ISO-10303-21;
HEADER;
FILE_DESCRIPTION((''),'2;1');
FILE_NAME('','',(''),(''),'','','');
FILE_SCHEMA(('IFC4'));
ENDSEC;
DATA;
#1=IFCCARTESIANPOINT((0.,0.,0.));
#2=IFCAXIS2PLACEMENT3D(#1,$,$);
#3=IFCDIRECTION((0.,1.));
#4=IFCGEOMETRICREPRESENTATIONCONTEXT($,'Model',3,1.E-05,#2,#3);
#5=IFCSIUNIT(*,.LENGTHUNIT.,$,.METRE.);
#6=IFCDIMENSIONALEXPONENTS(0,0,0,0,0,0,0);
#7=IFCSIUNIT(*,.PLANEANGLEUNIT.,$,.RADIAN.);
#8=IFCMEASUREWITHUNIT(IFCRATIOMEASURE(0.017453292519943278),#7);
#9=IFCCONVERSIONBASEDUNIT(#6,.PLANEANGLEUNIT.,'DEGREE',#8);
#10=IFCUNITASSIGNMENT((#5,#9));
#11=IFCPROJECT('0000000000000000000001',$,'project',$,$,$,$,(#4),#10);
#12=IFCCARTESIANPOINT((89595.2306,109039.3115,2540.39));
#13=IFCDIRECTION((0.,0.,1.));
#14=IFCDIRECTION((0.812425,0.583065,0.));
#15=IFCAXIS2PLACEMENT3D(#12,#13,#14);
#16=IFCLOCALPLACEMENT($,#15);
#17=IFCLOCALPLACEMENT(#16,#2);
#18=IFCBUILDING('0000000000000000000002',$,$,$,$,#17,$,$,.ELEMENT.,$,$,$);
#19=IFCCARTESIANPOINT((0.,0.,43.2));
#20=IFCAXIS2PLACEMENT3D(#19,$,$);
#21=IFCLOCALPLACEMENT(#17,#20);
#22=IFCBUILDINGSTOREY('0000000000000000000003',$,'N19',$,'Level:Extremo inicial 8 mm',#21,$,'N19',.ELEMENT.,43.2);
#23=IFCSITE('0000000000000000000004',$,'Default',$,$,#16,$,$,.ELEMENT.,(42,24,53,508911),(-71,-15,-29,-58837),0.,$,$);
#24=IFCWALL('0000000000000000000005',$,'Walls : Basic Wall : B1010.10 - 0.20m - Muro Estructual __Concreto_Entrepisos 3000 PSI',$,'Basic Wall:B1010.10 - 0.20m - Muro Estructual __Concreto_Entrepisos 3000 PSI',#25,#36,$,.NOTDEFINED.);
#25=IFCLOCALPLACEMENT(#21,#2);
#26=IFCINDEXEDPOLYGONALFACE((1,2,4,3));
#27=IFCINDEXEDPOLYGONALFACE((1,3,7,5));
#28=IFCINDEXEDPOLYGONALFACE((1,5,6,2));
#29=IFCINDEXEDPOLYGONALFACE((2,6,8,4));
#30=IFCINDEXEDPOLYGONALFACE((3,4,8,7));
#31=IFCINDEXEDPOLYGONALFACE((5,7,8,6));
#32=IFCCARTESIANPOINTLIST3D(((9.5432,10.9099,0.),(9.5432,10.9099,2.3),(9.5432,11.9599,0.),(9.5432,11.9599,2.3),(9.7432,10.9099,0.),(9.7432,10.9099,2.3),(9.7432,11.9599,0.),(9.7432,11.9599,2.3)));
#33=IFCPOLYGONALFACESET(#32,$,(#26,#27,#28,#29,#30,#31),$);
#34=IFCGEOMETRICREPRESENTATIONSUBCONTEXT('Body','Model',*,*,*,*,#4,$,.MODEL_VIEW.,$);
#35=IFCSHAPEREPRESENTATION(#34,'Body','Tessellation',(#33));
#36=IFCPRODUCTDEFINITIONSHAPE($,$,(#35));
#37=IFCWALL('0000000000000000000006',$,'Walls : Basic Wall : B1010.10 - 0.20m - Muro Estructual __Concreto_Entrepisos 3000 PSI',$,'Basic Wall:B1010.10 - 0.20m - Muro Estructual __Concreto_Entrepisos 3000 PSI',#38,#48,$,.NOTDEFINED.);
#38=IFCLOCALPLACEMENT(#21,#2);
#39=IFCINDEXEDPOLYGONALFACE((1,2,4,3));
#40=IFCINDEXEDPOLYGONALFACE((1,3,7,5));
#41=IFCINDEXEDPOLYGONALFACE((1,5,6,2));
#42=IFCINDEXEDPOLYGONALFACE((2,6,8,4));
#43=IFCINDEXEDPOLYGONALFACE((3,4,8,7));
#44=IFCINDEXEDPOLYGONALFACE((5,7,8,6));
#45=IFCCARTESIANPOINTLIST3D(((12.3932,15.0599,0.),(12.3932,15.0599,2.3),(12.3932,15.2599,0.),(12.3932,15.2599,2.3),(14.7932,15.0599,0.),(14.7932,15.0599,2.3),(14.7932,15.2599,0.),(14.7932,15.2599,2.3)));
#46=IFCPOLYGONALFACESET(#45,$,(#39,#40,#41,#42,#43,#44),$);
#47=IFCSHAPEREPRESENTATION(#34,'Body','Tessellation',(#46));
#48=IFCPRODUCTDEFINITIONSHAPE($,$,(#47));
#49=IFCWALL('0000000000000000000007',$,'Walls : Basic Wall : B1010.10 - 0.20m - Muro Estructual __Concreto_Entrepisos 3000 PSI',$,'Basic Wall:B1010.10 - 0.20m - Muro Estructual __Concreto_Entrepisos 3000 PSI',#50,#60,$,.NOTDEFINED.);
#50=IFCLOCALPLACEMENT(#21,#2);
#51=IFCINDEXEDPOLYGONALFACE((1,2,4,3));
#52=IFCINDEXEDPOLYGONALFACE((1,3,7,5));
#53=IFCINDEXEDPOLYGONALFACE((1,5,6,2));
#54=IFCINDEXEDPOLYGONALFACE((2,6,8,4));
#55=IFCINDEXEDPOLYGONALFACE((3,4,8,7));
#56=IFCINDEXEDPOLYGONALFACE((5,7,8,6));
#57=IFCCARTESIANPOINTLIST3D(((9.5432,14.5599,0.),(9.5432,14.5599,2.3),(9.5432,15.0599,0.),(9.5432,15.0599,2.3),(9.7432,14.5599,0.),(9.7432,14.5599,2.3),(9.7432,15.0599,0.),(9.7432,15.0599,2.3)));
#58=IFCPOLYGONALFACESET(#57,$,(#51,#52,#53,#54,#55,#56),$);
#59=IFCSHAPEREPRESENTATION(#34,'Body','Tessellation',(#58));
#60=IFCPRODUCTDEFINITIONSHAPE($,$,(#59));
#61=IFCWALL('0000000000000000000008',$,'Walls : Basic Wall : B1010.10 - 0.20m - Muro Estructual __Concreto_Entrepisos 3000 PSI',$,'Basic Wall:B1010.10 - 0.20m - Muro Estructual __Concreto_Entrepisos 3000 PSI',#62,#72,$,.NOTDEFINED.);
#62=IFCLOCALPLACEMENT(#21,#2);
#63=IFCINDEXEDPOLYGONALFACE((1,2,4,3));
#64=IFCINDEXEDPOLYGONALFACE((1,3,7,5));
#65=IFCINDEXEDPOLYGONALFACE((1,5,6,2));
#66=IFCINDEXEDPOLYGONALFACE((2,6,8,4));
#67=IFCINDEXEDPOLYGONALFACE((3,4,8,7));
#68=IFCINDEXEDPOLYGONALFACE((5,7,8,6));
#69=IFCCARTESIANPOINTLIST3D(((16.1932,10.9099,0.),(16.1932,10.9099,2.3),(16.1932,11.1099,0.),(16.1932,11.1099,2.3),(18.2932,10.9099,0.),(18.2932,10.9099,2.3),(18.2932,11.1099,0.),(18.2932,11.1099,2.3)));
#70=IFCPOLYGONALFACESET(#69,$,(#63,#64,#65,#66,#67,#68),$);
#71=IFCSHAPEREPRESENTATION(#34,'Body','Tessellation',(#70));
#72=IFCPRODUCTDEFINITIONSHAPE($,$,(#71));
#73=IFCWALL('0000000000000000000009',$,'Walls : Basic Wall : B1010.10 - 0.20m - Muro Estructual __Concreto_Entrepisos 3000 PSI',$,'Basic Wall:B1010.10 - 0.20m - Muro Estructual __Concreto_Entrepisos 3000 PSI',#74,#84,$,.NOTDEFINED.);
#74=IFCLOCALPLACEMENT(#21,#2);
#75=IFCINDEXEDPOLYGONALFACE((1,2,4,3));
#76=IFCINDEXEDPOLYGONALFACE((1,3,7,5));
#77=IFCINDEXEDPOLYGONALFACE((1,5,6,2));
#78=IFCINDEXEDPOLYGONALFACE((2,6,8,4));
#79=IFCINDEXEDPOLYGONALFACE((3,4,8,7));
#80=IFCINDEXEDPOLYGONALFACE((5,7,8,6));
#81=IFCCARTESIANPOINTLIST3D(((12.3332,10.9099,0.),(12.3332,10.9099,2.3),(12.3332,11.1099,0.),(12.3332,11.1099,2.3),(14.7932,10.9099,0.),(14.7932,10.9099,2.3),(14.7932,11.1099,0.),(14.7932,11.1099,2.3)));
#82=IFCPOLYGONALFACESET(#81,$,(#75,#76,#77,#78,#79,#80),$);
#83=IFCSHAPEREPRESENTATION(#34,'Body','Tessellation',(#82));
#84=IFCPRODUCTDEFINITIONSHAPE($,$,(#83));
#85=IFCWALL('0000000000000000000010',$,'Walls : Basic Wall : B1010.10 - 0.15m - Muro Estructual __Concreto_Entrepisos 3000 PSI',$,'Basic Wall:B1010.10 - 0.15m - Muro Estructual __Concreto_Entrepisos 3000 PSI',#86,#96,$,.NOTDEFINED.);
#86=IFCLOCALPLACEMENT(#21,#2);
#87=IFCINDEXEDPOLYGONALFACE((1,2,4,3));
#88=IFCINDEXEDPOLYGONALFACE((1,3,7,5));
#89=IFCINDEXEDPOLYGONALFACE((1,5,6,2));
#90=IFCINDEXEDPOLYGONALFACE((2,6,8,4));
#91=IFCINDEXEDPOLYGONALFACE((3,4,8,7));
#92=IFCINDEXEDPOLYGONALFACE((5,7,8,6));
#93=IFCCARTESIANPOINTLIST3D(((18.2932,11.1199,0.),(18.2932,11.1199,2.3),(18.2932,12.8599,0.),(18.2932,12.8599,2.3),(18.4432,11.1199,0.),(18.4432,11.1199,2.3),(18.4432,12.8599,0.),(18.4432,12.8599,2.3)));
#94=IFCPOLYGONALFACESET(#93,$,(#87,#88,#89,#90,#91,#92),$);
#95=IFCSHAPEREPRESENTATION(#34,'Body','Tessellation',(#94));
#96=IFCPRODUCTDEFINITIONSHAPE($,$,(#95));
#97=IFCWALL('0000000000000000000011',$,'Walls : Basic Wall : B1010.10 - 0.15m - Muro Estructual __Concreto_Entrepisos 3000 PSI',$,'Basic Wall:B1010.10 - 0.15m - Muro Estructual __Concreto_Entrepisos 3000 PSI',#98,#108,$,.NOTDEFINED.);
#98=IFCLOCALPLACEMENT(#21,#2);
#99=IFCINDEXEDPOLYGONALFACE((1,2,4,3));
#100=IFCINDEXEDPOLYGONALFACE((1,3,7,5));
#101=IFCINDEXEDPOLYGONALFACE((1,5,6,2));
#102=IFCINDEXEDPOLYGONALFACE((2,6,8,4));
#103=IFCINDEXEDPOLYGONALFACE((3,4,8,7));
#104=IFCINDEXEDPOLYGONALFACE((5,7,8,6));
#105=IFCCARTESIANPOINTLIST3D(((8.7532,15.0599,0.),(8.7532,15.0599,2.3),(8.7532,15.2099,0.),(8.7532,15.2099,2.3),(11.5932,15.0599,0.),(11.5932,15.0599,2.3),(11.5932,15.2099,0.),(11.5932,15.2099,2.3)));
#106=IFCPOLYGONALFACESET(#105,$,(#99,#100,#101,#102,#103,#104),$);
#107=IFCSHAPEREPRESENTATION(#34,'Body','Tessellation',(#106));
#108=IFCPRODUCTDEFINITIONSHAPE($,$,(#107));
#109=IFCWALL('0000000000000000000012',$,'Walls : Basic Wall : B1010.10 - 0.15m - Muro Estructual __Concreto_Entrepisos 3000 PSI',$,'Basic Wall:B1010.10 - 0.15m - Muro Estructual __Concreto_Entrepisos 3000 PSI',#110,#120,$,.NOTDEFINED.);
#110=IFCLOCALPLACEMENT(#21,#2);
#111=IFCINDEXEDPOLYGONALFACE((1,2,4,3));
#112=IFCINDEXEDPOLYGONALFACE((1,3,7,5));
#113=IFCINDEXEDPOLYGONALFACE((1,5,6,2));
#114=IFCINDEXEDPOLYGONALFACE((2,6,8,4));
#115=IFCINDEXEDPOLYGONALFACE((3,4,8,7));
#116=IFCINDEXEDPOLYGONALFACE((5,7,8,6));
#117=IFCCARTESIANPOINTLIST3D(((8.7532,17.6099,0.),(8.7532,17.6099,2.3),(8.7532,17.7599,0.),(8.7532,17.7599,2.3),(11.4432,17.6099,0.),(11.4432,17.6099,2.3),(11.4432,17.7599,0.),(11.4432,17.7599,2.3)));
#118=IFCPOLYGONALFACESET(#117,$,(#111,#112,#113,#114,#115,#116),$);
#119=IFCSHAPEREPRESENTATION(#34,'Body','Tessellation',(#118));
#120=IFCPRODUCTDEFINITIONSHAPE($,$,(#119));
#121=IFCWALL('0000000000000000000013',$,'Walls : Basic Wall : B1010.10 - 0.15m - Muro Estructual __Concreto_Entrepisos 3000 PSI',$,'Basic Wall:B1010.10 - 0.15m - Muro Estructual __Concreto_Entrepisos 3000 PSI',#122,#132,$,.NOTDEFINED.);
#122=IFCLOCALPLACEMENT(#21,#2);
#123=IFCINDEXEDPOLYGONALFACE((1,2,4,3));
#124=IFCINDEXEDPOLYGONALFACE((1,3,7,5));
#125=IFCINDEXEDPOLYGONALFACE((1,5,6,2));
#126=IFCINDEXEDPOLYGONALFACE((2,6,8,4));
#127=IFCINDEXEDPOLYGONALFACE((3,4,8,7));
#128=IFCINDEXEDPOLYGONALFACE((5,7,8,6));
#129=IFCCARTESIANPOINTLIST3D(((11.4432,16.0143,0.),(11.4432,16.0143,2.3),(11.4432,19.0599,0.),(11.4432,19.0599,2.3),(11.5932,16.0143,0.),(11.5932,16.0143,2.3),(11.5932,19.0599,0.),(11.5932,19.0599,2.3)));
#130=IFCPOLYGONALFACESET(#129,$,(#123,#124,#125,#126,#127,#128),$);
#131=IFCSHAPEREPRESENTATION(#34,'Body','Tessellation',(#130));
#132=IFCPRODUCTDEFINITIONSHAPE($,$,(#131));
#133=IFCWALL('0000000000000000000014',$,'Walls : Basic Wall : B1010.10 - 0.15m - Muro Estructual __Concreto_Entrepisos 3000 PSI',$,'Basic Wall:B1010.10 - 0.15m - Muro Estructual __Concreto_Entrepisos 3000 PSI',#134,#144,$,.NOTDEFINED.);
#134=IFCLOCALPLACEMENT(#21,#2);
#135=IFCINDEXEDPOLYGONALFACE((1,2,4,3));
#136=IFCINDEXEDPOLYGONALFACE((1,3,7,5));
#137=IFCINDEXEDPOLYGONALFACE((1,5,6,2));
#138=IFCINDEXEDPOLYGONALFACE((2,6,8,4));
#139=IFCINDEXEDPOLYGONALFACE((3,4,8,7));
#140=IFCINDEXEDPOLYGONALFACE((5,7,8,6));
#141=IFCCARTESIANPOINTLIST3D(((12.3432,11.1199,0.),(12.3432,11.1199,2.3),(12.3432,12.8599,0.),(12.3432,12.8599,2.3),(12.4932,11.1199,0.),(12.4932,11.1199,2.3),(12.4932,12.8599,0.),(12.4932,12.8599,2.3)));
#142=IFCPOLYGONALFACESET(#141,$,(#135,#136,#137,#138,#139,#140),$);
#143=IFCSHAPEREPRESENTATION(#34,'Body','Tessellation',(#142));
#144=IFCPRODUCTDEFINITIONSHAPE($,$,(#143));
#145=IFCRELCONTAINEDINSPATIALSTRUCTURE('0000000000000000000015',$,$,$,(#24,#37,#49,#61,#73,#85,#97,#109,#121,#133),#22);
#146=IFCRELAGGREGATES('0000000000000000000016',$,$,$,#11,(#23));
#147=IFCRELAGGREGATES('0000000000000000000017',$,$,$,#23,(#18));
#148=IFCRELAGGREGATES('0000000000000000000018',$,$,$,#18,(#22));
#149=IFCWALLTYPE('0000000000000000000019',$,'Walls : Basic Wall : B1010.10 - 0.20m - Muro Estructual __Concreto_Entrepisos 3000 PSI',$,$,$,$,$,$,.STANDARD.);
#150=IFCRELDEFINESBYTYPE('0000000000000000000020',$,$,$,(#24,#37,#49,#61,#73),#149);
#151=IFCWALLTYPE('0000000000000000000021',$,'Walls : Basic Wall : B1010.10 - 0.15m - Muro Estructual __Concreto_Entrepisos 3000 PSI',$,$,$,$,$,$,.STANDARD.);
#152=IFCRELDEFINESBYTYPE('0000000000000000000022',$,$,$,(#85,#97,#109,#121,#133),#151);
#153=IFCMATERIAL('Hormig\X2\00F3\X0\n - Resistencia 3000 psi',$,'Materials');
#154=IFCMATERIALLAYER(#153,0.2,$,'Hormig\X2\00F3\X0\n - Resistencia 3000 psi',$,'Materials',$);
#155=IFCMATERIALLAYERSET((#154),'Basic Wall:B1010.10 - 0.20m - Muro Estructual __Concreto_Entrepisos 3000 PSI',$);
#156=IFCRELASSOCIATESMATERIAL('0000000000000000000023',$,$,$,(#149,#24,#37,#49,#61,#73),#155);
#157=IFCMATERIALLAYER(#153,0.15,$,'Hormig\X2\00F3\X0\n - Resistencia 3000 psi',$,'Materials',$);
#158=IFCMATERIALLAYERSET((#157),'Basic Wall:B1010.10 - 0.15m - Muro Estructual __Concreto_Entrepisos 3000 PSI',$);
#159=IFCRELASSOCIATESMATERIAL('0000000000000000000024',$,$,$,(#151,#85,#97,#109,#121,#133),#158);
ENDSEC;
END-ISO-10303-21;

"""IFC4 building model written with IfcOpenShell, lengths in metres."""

from ifc_helpers import new_model, entity, si_unit, converted_unit, direction, frame, frame_2d, origin, place, context, subcontext, project, spatial, rectangle, extrude, material, layer, layer_set, layer_usage, type_object, element, save


model = new_model("IFC4")

# Units and contexts
model_context = context("Model", 3, precision=1e-05, world=origin(), true_north=direction((0.0, 1.0)))
body_context = subcontext(model_context, "Body", "Model", "MODEL_VIEW")
ifc_project = project(units=[si_unit("LENGTHUNIT", "METRE"), converted_unit("PLANEANGLEUNIT", "DEGREE", entity("IfcRatioMeasure", 0.017453292519943278), si_unit("PLANEANGLEUNIT", "RADIAN"), dimensions=[0, 0, 0, 0, 0, 0, 0])], contexts=[model_context])

# Site, building, storey
site_placement = place(None, frame((89595.2306, 109039.3115, 2540.39), z_axis=(0.0, 0.0, 1.0), x_axis=(0.812425, 0.583065, 0.0)))
site = spatial("IfcSite", under=ifc_project, at=site_placement, Name="Default", CompositionType="ELEMENT", RefLatitude=(42, 24, 53, 508911), RefLongitude=(-71, -15, -29, -58837), RefElevation=0.0)
building_placement = place(site_placement, origin())
building = spatial("IfcBuilding", under=site, at=building_placement, CompositionType="ELEMENT")
storey_placement = place(building_placement, frame((0.0, 0.0, 43.2)))
storey = spatial("IfcBuildingStorey", under=building, at=storey_placement, Name="N19", ObjectType="Level:Extremo inicial 8 mm", LongName="N19", CompositionType="ELEMENT", Elevation=43.2)

# Walls
ifc_material = material(Name="Hormigón - Resistencia 3000 psi", Category="Materials")
ifc_layer_1 = layer(ifc_material, 0.2, Name="Hormigón - Resistencia 3000 psi", Category="Materials")
ifc_layer_set_1 = layer_set([ifc_layer_1], Name="Basic Wall:B1010.10 - 0.20m - Muro Estructual __Concreto_Entrepisos 3000 PSI")
ifc_layer_usage_1 = layer_usage(ifc_layer_set_1, "AXIS2", "POSITIVE", -0.1)
wall_type_1 = type_object("IfcWallType", Name="Walls : Basic Wall : B1010.10 - 0.20m - Muro Estructual __Concreto_Entrepisos 3000 PSI", PredefinedType="STANDARD", material=ifc_layer_set_1)
wall_1_placement = place(storey_placement, frame((9.6432, 11.9599, 0.0), z_axis=(0.0, 0.0, 1.0), x_axis=(0.0, -1.0, 0.0)))
element("IfcWall", 1, at=wall_1_placement, inside=storey, type_object=wall_type_1, material=ifc_layer_usage_1, Name="Walls : Basic Wall : B1010.10 - 0.20m - Muro Estructual __Concreto_Entrepisos 3000 PSI", ObjectType="Basic Wall:B1010.10 - 0.20m - Muro Estructual __Concreto_Entrepisos 3000 PSI", PredefinedType="NOTDEFINED", context=body_context, shape_type="SweptSolid", body=[
    extrude(rectangle(XDim=1.05, YDim=0.2, at=frame_2d((0.525, 0.0), x_axis=(-1.0, 0.0))), origin(), (0.0, 0.0, 1.0), 2.3),
])
ifc_layer_usage_2 = layer_usage(ifc_layer_set_1, "AXIS2", "POSITIVE", -0.1)
wall_2_placement = place(storey_placement, frame((12.3932, 15.1599, 0.0)))
element("IfcWall", 2, at=wall_2_placement, inside=storey, type_object=wall_type_1, material=ifc_layer_usage_2, Name="Walls : Basic Wall : B1010.10 - 0.20m - Muro Estructual __Concreto_Entrepisos 3000 PSI", ObjectType="Basic Wall:B1010.10 - 0.20m - Muro Estructual __Concreto_Entrepisos 3000 PSI", PredefinedType="NOTDEFINED", context=body_context, shape_type="SweptSolid", body=[
    extrude(rectangle(XDim=2.4, YDim=0.2, at=frame_2d((1.2, 0.0), x_axis=(-1.0, 0.0))), origin(), (0.0, 0.0, 1.0), 2.3),
])
ifc_layer_usage_3 = layer_usage(ifc_layer_set_1, "AXIS2", "POSITIVE", -0.1)
wall_3_placement = place(storey_placement, frame((9.6432, 14.5599, 0.0), z_axis=(0.0, 0.0, 1.0), x_axis=(0.0, 1.0, 0.0)))
element("IfcWall", 3, at=wall_3_placement, inside=storey, type_object=wall_type_1, material=ifc_layer_usage_3, Name="Walls : Basic Wall : B1010.10 - 0.20m - Muro Estructual __Concreto_Entrepisos 3000 PSI", ObjectType="Basic Wall:B1010.10 - 0.20m - Muro Estructual __Concreto_Entrepisos 3000 PSI", PredefinedType="NOTDEFINED", context=body_context, shape_type="SweptSolid", body=[
    extrude(rectangle(XDim=0.5, YDim=0.2, at=frame_2d((0.25, 0.0), x_axis=(-1.0, 0.0))), origin(), (0.0, 0.0, 1.0), 2.3),
])
ifc_layer_usage_4 = layer_usage(ifc_layer_set_1, "AXIS2", "NEGATIVE", 0.1)
wall_4_placement = place(storey_placement, frame((18.2932, 11.0099, 0.0), z_axis=(0.0, 0.0, 1.0), x_axis=(-1.0, 0.0, 0.0)))
element("IfcWall", 4, at=wall_4_placement, inside=storey, type_object=wall_type_1, material=ifc_layer_usage_4, Name="Walls : Basic Wall : B1010.10 - 0.20m - Muro Estructual __Concreto_Entrepisos 3000 PSI", ObjectType="Basic Wall:B1010.10 - 0.20m - Muro Estructual __Concreto_Entrepisos 3000 PSI", PredefinedType="NOTDEFINED", context=body_context, shape_type="SweptSolid", body=[
    extrude(rectangle(XDim=2.1, YDim=0.2, at=frame_2d((1.05, 0.0), x_axis=(-1.0, 0.0))), origin(), (0.0, 0.0, 1.0), 2.3),
])
ifc_layer_usage_5 = layer_usage(ifc_layer_set_1, "AXIS2", "POSITIVE", -0.1)
wall_5_placement = place(storey_placement, frame((12.3332, 11.0099, 0.0)))
element("IfcWall", 5, at=wall_5_placement, inside=storey, type_object=wall_type_1, material=ifc_layer_usage_5, Name="Walls : Basic Wall : B1010.10 - 0.20m - Muro Estructual __Concreto_Entrepisos 3000 PSI", ObjectType="Basic Wall:B1010.10 - 0.20m - Muro Estructual __Concreto_Entrepisos 3000 PSI", PredefinedType="NOTDEFINED", context=body_context, shape_type="SweptSolid", body=[
    extrude(rectangle(XDim=2.46, YDim=0.2, at=frame_2d((1.23, 0.0), x_axis=(-1.0, 0.0))), origin(), (0.0, 0.0, 1.0), 2.3),
])
ifc_layer_2 = layer(ifc_material, 0.15, Name="Hormigón - Resistencia 3000 psi", Category="Materials")
ifc_layer_set_2 = layer_set([ifc_layer_2], Name="Basic Wall:B1010.10 - 0.15m - Muro Estructual __Concreto_Entrepisos 3000 PSI")
ifc_layer_usage_6 = layer_usage(ifc_layer_set_2, "AXIS2", "NEGATIVE", 0.075)
wall_type_2 = type_object("IfcWallType", Name="Walls : Basic Wall : B1010.10 - 0.15m - Muro Estructual __Concreto_Entrepisos 3000 PSI", PredefinedType="STANDARD", material=ifc_layer_set_2)
wall_6_placement = place(storey_placement, frame((18.3682, 11.1199, 0.0), z_axis=(0.0, 0.0, 1.0), x_axis=(0.0, 1.0, 0.0)))
element("IfcWall", 6, at=wall_6_placement, inside=storey, type_object=wall_type_2, material=ifc_layer_usage_6, Name="Walls : Basic Wall : B1010.10 - 0.15m - Muro Estructual __Concreto_Entrepisos 3000 PSI", ObjectType="Basic Wall:B1010.10 - 0.15m - Muro Estructual __Concreto_Entrepisos 3000 PSI", PredefinedType="NOTDEFINED", context=body_context, shape_type="SweptSolid", body=[
    extrude(rectangle(XDim=1.74, YDim=0.15, at=frame_2d((0.87, 0.0), x_axis=(-1.0, 0.0))), origin(), (0.0, 0.0, 1.0), 2.3),
])
ifc_layer_usage_7 = layer_usage(ifc_layer_set_2, "AXIS2", "POSITIVE", -0.075)
wall_7_placement = place(storey_placement, frame((8.7532, 15.1349, 0.0)))
element("IfcWall", 7, at=wall_7_placement, inside=storey, type_object=wall_type_2, material=ifc_layer_usage_7, Name="Walls : Basic Wall : B1010.10 - 0.15m - Muro Estructual __Concreto_Entrepisos 3000 PSI", ObjectType="Basic Wall:B1010.10 - 0.15m - Muro Estructual __Concreto_Entrepisos 3000 PSI", PredefinedType="NOTDEFINED", context=body_context, shape_type="SweptSolid", body=[
    extrude(rectangle(XDim=2.84, YDim=0.15, at=frame_2d((1.42, 0.0), x_axis=(-1.0, 0.0))), origin(), (0.0, 0.0, 1.0), 2.3),
])
ifc_layer_usage_8 = layer_usage(ifc_layer_set_2, "AXIS2", "POSITIVE", -0.075)
wall_8_placement = place(storey_placement, frame((8.7532, 17.6849, 0.0)))
element("IfcWall", 8, at=wall_8_placement, inside=storey, type_object=wall_type_2, material=ifc_layer_usage_8, Name="Walls : Basic Wall : B1010.10 - 0.15m - Muro Estructual __Concreto_Entrepisos 3000 PSI", ObjectType="Basic Wall:B1010.10 - 0.15m - Muro Estructual __Concreto_Entrepisos 3000 PSI", PredefinedType="NOTDEFINED", context=body_context, shape_type="SweptSolid", body=[
    extrude(rectangle(XDim=2.69, YDim=0.15, at=frame_2d((1.345, 0.0), x_axis=(-1.0, 0.0))), origin(), (0.0, 0.0, 1.0), 2.3),
])
ifc_layer_usage_9 = layer_usage(ifc_layer_set_2, "AXIS2", "POSITIVE", -0.075)
wall_9_placement = place(storey_placement, frame((11.5182, 16.0143, 0.0), z_axis=(0.0, 0.0, 1.0), x_axis=(0.0, 1.0, 0.0)))
element("IfcWall", 9, at=wall_9_placement, inside=storey, type_object=wall_type_2, material=ifc_layer_usage_9, Name="Walls : Basic Wall : B1010.10 - 0.15m - Muro Estructual __Concreto_Entrepisos 3000 PSI", ObjectType="Basic Wall:B1010.10 - 0.15m - Muro Estructual __Concreto_Entrepisos 3000 PSI", PredefinedType="NOTDEFINED", context=body_context, shape_type="SweptSolid", body=[
    extrude(rectangle(XDim=3.0455, YDim=0.15, at=frame_2d((1.5228, 0.0), x_axis=(-1.0, 0.0))), origin(), (0.0, 0.0, 1.0), 2.3),
])
ifc_layer_usage_10 = layer_usage(ifc_layer_set_2, "AXIS2", "POSITIVE", -0.075)
wall_10_placement = place(storey_placement, frame((12.4182, 11.1199, 0.0), z_axis=(0.0, 0.0, 1.0), x_axis=(0.0, 1.0, 0.0)))
element("IfcWall", 10, at=wall_10_placement, inside=storey, type_object=wall_type_2, material=ifc_layer_usage_10, Name="Walls : Basic Wall : B1010.10 - 0.15m - Muro Estructual __Concreto_Entrepisos 3000 PSI", ObjectType="Basic Wall:B1010.10 - 0.15m - Muro Estructual __Concreto_Entrepisos 3000 PSI", PredefinedType="NOTDEFINED", context=body_context, shape_type="SweptSolid", body=[
    extrude(rectangle(XDim=1.74, YDim=0.15, at=frame_2d((0.87, 0.0), x_axis=(-1.0, 0.0))), origin(), (0.0, 0.0, 1.0), 2.3),
])

save(model, "model.ifc")
